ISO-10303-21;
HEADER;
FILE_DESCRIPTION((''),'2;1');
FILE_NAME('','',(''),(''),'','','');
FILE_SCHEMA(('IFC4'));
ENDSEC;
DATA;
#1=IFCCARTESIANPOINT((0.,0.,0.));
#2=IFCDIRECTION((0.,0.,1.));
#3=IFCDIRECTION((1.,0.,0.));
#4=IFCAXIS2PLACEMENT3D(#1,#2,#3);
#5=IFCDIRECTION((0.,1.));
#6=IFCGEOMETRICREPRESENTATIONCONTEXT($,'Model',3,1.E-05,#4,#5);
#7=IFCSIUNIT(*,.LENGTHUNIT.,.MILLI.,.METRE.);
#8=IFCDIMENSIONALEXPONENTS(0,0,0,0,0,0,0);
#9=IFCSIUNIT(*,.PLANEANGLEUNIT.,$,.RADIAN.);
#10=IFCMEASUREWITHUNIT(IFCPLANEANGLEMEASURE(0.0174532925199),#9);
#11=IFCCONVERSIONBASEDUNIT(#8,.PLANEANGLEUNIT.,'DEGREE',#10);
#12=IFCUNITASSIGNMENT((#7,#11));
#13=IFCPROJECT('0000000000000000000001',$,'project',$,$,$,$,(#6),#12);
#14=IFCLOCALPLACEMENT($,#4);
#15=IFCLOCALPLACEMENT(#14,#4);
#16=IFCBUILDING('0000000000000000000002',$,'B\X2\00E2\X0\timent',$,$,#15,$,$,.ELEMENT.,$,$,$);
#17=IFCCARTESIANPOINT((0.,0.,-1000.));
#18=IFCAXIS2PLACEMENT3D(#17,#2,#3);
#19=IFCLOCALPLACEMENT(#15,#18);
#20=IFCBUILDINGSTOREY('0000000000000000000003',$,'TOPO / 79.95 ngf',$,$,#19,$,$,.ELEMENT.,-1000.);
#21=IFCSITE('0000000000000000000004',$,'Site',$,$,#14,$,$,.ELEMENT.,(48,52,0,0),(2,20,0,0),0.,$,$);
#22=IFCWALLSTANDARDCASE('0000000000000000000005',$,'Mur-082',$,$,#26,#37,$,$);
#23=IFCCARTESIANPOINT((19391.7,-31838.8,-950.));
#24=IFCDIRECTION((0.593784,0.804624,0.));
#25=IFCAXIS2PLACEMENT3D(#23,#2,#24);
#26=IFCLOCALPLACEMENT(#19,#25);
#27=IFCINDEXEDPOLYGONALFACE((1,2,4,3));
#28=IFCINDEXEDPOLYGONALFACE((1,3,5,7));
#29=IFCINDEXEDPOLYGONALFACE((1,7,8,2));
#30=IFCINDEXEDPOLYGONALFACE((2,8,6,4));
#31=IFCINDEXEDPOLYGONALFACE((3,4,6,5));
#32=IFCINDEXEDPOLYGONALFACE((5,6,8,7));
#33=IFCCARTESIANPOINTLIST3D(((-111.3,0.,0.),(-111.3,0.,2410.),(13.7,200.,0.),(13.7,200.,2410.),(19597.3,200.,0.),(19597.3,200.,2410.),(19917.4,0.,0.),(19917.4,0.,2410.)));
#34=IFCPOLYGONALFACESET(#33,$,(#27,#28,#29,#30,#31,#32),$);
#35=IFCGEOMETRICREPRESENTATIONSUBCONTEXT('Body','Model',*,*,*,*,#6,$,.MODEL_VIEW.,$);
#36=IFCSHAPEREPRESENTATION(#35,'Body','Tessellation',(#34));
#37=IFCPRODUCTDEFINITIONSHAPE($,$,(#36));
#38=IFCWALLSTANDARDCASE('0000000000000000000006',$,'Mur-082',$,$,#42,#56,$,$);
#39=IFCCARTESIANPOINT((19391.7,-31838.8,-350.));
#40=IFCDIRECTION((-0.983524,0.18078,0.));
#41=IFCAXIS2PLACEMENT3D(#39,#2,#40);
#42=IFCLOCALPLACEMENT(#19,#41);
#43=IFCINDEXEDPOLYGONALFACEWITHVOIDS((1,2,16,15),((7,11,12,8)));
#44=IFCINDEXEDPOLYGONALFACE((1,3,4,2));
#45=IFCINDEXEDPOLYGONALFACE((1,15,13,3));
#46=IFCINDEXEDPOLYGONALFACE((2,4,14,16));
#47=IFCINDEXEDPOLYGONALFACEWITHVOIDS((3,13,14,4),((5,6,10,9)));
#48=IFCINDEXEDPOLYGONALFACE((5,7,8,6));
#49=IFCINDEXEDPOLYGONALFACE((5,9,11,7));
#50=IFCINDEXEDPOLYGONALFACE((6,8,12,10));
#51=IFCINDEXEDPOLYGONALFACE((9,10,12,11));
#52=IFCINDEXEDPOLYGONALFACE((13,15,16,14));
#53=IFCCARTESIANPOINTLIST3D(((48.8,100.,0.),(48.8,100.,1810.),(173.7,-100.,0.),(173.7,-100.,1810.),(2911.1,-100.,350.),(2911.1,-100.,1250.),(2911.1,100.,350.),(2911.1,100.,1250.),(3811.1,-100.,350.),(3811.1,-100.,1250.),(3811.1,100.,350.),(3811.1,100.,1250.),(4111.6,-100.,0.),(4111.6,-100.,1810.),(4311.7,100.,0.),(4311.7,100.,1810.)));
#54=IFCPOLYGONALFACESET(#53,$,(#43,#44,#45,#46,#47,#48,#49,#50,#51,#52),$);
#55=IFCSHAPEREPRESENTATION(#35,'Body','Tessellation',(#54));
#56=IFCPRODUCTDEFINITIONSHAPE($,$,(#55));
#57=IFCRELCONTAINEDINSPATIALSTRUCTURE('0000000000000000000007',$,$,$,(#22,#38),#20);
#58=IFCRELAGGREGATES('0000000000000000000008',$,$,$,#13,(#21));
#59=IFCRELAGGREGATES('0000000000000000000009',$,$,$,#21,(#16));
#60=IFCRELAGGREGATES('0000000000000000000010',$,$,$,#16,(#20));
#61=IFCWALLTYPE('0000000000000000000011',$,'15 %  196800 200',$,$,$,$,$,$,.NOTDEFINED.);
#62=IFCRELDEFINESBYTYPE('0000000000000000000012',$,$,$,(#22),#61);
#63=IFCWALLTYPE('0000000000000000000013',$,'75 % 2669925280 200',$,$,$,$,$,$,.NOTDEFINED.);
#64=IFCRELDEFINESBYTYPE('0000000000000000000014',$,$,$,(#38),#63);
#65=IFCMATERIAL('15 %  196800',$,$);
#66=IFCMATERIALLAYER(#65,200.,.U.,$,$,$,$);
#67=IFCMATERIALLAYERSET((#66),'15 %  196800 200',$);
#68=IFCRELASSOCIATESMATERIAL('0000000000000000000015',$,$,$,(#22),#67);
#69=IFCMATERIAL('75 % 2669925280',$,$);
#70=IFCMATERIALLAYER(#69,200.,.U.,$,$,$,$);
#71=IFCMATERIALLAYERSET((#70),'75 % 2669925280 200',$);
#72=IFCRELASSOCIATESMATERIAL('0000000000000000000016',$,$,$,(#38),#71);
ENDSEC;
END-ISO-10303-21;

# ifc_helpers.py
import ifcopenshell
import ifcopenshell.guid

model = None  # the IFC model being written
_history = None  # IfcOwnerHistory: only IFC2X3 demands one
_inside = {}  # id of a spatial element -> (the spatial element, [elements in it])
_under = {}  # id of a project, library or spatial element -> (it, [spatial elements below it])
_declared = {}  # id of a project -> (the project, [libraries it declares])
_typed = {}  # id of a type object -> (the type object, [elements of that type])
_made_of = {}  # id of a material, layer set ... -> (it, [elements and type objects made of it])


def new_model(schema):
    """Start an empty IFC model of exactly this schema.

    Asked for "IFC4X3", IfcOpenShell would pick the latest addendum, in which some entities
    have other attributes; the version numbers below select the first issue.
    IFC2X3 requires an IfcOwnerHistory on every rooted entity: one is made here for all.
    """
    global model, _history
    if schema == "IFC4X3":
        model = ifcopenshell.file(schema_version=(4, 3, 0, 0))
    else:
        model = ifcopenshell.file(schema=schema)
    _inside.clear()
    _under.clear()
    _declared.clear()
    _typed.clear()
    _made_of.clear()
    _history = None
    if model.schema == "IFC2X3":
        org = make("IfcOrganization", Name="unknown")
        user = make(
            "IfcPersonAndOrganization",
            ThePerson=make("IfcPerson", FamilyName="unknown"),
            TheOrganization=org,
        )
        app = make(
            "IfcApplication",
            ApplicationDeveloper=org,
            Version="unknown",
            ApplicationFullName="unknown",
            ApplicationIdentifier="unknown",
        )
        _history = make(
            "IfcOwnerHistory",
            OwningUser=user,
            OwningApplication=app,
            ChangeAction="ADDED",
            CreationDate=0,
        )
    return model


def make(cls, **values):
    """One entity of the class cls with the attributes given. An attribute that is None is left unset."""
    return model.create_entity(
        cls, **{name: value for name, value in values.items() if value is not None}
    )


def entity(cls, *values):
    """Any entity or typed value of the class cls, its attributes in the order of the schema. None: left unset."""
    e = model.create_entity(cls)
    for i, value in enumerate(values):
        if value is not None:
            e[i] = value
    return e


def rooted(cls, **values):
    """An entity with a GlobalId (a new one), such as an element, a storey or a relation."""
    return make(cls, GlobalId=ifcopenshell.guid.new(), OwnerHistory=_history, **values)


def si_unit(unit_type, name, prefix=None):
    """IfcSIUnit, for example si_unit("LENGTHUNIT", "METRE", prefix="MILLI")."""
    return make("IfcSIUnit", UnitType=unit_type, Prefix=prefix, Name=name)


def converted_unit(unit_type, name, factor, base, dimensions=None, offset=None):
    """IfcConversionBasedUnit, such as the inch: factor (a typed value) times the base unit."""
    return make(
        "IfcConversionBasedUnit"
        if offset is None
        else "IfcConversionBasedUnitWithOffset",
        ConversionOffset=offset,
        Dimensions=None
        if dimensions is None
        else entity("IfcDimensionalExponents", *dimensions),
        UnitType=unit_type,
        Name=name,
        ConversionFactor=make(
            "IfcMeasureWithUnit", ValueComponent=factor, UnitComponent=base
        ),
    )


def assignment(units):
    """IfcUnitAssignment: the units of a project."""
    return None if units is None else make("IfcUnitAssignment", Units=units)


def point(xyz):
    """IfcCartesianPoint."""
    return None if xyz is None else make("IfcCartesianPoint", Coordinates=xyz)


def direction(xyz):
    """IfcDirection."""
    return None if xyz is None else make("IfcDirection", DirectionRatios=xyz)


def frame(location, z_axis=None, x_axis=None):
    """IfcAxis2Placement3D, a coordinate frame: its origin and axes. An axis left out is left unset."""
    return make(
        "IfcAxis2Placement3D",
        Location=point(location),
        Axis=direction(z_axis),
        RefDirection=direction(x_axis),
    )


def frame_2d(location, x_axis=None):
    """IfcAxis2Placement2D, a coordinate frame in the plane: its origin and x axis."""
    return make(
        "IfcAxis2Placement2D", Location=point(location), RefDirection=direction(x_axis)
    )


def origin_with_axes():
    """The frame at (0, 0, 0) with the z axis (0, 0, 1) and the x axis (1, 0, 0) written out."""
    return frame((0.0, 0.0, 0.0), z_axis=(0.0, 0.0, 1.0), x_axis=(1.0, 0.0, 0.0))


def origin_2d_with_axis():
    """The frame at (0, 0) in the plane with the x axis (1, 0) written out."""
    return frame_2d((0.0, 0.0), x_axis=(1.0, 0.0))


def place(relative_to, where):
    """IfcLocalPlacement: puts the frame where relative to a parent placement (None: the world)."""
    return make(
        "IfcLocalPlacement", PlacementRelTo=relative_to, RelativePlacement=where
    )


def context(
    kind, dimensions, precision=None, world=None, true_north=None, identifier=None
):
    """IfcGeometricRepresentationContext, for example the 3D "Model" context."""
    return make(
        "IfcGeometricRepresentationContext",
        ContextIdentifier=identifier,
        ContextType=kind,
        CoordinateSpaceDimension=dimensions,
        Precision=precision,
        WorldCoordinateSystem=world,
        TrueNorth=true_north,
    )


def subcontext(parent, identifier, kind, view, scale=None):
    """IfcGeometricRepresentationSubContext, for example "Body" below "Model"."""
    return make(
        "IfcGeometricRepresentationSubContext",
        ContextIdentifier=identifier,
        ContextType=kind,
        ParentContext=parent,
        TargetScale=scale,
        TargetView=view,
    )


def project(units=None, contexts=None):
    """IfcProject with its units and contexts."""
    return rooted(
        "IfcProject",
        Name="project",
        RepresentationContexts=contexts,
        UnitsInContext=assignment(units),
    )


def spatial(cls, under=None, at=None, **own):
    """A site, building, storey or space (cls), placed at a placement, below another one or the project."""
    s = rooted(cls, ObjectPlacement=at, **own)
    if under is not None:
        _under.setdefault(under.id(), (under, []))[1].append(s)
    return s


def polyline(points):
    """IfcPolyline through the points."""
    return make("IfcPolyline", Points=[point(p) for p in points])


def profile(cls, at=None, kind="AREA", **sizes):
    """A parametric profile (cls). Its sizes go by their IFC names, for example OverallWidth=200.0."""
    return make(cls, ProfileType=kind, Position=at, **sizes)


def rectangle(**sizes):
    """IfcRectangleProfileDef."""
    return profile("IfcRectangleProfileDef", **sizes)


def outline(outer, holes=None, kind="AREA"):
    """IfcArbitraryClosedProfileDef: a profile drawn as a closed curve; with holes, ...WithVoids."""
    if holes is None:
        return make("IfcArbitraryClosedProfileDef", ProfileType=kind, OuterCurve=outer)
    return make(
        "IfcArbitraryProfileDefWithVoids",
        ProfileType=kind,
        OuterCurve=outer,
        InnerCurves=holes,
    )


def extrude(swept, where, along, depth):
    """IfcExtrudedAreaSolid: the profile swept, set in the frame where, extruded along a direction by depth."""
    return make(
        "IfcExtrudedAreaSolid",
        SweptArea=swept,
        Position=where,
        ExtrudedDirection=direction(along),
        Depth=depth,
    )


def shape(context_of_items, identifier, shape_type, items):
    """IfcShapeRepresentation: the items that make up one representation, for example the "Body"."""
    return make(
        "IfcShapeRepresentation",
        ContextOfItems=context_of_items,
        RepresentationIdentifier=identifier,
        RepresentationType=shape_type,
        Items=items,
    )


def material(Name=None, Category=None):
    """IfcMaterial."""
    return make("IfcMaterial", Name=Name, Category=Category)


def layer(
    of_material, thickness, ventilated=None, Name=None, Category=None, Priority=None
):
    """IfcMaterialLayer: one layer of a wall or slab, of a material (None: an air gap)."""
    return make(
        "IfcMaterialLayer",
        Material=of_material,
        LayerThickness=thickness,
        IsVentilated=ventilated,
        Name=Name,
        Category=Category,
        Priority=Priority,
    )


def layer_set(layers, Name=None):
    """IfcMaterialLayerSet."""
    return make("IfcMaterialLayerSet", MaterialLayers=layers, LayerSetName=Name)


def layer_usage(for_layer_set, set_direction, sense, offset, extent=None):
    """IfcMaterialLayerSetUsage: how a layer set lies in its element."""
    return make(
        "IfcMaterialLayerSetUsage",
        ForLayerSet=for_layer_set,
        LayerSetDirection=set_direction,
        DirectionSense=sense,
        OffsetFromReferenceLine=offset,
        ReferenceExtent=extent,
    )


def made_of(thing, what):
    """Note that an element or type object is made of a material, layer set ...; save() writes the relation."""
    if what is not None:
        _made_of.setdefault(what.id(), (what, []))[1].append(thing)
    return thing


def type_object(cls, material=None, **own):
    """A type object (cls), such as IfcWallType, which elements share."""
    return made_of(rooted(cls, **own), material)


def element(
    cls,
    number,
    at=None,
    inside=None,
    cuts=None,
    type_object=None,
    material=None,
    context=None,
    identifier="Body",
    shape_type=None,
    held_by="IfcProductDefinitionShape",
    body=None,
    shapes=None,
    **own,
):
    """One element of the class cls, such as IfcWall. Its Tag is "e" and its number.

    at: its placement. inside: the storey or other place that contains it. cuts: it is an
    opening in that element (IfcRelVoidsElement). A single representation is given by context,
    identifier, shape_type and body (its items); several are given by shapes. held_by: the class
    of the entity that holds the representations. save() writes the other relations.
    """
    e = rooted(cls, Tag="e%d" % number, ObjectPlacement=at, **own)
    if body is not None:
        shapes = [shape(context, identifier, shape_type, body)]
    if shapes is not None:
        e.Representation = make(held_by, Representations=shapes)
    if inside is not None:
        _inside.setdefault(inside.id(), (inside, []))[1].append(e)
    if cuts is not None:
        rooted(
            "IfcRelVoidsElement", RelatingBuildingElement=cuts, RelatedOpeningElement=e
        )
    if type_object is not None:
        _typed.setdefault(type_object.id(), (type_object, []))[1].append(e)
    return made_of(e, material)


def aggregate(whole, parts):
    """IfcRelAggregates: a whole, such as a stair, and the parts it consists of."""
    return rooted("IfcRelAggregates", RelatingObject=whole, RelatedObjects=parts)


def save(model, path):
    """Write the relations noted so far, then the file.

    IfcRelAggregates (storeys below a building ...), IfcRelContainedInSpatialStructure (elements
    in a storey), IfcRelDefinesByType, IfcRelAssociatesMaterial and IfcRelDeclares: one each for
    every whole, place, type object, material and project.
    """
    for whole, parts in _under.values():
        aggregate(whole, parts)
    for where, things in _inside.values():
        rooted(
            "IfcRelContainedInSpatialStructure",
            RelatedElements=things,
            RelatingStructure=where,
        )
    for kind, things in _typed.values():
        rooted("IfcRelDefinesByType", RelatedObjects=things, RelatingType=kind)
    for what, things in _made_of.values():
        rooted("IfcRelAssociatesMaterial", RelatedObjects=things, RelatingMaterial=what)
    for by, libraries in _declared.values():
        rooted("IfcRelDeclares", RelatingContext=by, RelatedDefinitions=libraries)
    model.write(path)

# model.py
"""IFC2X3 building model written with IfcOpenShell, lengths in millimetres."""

from ifc_helpers import new_model, entity, si_unit, converted_unit, direction, frame, origin_with_axes, origin_2d_with_axis, place, context, subcontext, project, spatial, polyline, rectangle, outline, extrude, material, layer, layer_set, layer_usage, type_object, element, save


model = new_model("IFC2X3")

# Units and contexts
model_context = context("Model", 3, precision=1e-05, world=origin_with_axes(), true_north=direction((0.0, 1.0)))
body_context = subcontext(model_context, "Body", "Model", "MODEL_VIEW")
ifc_project = project(units=[si_unit("LENGTHUNIT", "METRE", prefix="MILLI"), converted_unit("PLANEANGLEUNIT", "DEGREE", entity("IfcPlaneAngleMeasure", 0.0174532925199), si_unit("PLANEANGLEUNIT", "RADIAN"), dimensions=[0, 0, 0, 0, 0, 0, 0])], contexts=[model_context])

# Site, building, storey
site_placement = place(None, origin_with_axes())
site = spatial("IfcSite", under=ifc_project, at=site_placement, Name="Site", CompositionType="ELEMENT", RefLatitude=(48, 52, 0, 0), RefLongitude=(2, 20, 0, 0), RefElevation=0.0)
building_placement = place(site_placement, origin_with_axes())
building = spatial("IfcBuilding", under=site, at=building_placement, Name="Bâtiment", CompositionType="ELEMENT")
storey_placement = place(building_placement, frame((0.0, 0.0, -1000.0), z_axis=(0.0, 0.0, 1.0), x_axis=(1.0, 0.0, 0.0)))
storey = spatial("IfcBuildingStorey", under=building, at=storey_placement, Name="TOPO / 79.95 ngf", CompositionType="ELEMENT", Elevation=-1000.0)

# Wall
ifc_material_1 = material(Name="15 %  196800")
ifc_layer_1 = layer(ifc_material_1, 200.0, ventilated="UNKNOWN")
ifc_layer_set_1 = layer_set([ifc_layer_1], Name="15 %  196800 200")
ifc_layer_usage_1 = layer_usage(ifc_layer_set_1, "AXIS2", "POSITIVE", 0.0)
wall_type_1 = type_object("IfcWallType", Name="15 %  196800 200", PredefinedType="NOTDEFINED")
wall_1_placement = place(storey_placement, frame((19391.7, -31838.8, -950.0), z_axis=(0.0, 0.0, 1.0), x_axis=(0.593784, 0.804624, 0.0)))
element("IfcWallStandardCase", 1, at=wall_1_placement, inside=storey, type_object=wall_type_1, material=ifc_layer_usage_1, Name="Mur-082", context=body_context, shape_type="SweptSolid", body=[
    extrude(outline(polyline([(-111.3, 0.0), (19917.4, 0.0), (19597.3, 200.0), (13.7, 200.0), (-111.3, 0.0)])), origin_with_axes(), (0.0, 0.0, 1.0), 2410.0),
])

# Wall, opening
ifc_material_2 = material(Name="75 % 2669925280")
ifc_layer_2 = layer(ifc_material_2, 200.0, ventilated="UNKNOWN")
ifc_layer_set_2 = layer_set([ifc_layer_2], Name="75 % 2669925280 200")
ifc_layer_usage_2 = layer_usage(ifc_layer_set_2, "AXIS2", "NEGATIVE", 100.0)
wall_type_2 = type_object("IfcWallType", Name="75 % 2669925280 200", PredefinedType="NOTDEFINED")
wall_2_placement = place(storey_placement, frame((19391.7, -31838.8, -350.0), z_axis=(0.0, 0.0, 1.0), x_axis=(-0.983524, 0.18078, 0.0)))
wall_2 = element("IfcWallStandardCase", 2, at=wall_2_placement, inside=storey, type_object=wall_type_2, material=ifc_layer_usage_2, Name="Mur-082", context=body_context, shape_type="SweptSolid", body=[
    extrude(outline(polyline([(173.7, -100.0), (4111.6, -100.0), (4311.7, 100.0), (48.8, 100.0), (173.7, -100.0)])), origin_with_axes(), (0.0, 0.0, 1.0), 1810.0),
])
opening_placement = place(wall_2_placement, frame((3361.1, 0.0, 350.0), z_axis=(0.0, 0.0, 1.0), x_axis=(1.0, 0.0, 0.0)))
element("IfcOpeningElement", 3, at=opening_placement, cuts=wall_2, context=body_context, shape_type="SweptSolid", body=[
    extrude(rectangle(XDim=900.0, YDim=900.0, at=origin_2d_with_axis()), frame((0.0, -300.0, 450.0), z_axis=(0.0, 1.0, 0.0), x_axis=(1.0, 0.0, 0.0)), (0.0, 0.0, 1.0), 600.0),
])

save(model, "model.ifc")
